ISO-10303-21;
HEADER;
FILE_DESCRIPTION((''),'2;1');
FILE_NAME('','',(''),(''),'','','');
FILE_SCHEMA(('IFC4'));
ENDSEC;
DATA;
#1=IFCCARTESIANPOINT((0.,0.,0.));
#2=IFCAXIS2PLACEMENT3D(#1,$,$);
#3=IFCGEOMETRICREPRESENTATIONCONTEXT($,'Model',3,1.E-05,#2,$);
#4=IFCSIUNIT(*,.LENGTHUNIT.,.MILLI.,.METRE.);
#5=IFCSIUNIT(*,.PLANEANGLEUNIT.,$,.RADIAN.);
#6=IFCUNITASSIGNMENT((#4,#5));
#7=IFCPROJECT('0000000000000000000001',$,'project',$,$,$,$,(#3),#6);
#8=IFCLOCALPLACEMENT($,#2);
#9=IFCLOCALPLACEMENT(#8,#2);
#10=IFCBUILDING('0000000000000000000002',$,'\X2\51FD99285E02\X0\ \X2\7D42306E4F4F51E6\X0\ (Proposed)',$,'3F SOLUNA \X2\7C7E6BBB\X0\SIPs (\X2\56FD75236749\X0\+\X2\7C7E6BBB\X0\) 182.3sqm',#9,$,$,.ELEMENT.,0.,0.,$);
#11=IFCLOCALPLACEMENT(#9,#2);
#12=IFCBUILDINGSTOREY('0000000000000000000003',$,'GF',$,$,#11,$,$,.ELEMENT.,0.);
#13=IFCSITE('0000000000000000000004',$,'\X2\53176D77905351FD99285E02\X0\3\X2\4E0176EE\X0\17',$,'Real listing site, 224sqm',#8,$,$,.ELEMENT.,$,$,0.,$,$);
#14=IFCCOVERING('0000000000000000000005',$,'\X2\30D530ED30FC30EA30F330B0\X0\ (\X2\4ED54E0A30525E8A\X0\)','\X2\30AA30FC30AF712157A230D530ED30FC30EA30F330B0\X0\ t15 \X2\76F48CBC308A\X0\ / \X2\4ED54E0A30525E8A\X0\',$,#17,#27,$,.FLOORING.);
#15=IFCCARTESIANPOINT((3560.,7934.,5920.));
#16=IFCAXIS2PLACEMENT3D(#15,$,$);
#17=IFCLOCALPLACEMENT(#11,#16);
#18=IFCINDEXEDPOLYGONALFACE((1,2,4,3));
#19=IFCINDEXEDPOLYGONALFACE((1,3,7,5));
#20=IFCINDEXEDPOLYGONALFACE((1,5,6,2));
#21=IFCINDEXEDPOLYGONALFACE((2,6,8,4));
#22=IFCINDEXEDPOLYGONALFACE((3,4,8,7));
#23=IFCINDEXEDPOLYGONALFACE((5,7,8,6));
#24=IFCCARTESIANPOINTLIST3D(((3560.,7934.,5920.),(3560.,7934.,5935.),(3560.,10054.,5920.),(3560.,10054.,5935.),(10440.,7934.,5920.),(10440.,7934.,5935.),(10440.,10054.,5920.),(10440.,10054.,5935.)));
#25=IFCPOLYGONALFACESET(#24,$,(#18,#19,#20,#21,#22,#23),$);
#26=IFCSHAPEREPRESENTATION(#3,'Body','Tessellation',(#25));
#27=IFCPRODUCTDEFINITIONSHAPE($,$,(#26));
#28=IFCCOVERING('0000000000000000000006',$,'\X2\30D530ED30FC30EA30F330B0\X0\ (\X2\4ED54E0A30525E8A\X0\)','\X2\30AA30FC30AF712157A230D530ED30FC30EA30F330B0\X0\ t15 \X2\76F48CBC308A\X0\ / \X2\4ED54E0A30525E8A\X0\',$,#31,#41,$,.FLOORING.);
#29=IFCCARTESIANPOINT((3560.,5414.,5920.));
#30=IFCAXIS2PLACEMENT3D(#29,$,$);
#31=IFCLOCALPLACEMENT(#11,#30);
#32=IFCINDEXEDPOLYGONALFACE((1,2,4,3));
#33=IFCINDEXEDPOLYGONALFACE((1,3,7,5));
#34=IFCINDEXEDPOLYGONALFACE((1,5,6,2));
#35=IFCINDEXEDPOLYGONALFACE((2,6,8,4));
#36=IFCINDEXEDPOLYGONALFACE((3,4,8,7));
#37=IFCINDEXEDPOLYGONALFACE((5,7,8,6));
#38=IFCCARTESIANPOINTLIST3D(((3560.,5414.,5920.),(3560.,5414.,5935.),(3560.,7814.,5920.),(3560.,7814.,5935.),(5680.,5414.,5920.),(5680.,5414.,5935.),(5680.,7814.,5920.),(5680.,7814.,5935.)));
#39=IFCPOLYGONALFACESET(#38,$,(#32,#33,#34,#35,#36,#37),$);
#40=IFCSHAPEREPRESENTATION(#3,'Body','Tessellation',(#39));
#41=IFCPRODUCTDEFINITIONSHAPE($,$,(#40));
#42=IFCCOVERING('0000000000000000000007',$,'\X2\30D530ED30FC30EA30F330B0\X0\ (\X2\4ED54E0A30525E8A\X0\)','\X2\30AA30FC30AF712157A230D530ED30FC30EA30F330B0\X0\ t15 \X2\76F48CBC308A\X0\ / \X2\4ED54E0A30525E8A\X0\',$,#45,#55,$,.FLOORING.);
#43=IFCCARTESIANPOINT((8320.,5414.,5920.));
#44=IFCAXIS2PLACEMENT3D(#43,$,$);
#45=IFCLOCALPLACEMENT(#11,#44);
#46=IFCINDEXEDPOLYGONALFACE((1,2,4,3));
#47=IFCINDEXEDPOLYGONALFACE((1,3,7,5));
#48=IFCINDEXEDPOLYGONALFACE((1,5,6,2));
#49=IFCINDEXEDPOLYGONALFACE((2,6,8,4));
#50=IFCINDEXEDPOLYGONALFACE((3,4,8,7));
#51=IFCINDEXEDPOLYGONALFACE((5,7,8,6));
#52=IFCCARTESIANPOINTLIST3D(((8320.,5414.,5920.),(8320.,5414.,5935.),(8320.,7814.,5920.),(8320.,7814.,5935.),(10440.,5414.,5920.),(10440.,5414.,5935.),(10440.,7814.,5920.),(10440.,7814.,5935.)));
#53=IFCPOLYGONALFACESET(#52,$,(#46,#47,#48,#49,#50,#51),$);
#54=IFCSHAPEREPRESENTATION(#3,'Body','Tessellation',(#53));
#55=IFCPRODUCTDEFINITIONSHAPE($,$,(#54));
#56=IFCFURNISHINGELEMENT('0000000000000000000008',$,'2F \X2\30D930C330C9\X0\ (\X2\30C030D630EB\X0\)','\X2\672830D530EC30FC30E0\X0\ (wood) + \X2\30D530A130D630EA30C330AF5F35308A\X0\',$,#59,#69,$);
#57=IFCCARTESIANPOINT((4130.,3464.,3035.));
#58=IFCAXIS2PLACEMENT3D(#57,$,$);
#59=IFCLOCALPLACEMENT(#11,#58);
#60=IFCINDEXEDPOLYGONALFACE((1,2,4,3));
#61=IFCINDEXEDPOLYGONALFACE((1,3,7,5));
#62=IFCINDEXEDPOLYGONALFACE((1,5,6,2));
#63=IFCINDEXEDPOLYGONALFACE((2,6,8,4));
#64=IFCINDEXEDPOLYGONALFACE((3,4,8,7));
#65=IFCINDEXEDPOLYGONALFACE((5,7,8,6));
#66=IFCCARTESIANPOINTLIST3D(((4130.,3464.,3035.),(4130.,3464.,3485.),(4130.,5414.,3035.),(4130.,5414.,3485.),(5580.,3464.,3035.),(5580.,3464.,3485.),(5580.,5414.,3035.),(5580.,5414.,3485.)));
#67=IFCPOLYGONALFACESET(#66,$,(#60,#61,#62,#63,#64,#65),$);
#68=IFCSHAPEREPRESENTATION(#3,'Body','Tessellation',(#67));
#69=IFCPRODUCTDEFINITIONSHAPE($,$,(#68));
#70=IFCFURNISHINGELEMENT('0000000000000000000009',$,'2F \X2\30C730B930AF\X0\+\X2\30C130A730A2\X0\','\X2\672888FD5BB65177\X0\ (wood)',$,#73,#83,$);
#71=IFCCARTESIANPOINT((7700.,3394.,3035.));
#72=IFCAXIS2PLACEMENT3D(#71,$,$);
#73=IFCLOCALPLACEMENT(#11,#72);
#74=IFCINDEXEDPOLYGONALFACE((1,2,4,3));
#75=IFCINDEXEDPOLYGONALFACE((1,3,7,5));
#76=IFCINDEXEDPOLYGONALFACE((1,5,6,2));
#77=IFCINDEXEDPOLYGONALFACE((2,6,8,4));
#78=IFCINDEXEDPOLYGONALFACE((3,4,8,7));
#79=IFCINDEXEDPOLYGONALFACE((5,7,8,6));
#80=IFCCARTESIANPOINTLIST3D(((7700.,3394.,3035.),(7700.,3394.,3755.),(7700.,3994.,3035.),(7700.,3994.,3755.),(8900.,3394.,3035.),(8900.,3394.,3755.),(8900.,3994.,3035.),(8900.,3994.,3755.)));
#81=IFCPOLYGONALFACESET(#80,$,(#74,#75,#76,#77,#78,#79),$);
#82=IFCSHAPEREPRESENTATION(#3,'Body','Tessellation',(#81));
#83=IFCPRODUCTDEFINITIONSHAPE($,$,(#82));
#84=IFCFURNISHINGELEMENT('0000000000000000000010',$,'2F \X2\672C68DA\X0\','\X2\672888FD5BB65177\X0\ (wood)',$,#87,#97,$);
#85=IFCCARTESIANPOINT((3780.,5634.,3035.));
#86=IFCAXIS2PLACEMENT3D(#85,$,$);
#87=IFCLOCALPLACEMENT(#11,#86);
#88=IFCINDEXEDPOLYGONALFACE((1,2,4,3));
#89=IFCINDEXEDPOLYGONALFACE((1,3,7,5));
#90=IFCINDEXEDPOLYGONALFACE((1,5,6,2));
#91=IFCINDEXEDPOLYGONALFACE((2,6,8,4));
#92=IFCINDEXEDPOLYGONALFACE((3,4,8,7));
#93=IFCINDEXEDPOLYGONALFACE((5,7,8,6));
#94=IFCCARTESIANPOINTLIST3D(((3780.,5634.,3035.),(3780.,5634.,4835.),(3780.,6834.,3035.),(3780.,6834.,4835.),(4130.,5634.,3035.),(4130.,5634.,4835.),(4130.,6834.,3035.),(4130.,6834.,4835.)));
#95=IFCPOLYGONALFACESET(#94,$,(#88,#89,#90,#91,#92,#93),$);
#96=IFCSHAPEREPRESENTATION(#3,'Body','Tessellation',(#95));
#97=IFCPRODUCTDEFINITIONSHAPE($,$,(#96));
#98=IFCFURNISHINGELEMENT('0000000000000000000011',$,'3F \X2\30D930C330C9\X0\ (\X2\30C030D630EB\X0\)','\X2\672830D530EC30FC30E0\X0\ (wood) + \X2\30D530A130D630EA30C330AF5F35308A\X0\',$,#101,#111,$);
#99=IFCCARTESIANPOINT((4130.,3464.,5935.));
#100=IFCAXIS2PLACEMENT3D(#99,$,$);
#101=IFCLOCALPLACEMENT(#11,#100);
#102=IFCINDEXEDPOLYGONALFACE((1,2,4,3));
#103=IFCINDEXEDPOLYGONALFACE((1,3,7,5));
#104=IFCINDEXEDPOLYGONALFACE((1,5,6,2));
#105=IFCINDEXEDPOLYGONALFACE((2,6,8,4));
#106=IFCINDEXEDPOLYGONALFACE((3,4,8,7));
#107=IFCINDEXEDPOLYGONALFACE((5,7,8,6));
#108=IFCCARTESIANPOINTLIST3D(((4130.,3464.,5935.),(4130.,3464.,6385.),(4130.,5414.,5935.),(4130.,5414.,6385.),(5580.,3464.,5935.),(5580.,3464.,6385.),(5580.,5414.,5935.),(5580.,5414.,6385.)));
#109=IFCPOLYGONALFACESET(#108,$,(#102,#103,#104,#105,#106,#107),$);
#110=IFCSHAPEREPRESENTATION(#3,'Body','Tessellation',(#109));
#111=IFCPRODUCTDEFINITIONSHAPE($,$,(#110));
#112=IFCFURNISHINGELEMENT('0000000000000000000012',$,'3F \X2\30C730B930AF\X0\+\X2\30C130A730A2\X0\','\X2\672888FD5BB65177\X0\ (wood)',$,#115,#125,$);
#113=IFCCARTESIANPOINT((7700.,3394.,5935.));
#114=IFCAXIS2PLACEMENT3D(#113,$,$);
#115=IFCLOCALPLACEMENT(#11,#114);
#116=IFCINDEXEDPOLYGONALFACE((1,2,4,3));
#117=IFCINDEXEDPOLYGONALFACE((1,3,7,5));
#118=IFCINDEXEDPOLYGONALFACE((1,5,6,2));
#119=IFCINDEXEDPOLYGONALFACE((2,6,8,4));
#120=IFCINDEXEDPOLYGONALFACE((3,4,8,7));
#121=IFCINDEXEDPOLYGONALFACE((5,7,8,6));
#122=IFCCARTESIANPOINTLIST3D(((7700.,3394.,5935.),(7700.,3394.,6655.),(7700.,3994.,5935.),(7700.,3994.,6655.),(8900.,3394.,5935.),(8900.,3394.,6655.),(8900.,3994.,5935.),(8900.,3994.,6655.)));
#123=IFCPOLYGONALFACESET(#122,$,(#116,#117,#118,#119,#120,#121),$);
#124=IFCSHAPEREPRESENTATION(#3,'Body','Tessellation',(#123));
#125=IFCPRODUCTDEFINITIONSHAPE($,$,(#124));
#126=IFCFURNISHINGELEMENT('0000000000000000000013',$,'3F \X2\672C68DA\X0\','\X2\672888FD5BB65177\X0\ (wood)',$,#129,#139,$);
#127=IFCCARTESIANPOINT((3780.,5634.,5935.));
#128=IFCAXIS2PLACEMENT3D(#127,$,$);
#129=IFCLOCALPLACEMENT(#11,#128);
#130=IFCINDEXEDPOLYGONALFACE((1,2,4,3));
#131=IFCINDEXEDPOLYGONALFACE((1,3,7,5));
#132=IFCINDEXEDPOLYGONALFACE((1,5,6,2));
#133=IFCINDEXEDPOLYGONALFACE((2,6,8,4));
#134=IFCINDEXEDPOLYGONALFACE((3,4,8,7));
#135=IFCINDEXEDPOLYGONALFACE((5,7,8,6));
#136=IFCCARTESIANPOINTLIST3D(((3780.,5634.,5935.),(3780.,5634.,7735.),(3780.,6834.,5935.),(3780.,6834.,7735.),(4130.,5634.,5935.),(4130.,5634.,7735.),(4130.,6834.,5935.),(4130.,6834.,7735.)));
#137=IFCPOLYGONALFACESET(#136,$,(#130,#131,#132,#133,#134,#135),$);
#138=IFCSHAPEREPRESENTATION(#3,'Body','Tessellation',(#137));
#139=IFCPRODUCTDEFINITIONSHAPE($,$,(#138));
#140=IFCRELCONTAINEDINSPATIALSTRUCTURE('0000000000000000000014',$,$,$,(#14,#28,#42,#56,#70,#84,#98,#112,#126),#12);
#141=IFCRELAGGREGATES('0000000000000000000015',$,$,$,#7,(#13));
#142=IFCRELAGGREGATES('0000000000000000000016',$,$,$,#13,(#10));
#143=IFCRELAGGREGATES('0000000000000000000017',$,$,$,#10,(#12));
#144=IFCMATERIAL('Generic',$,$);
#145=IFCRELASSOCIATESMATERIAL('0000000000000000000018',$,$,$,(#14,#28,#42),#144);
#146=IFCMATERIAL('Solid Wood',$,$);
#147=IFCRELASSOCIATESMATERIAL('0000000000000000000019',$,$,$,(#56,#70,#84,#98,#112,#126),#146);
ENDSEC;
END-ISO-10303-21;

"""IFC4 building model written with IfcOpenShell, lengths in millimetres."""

from ifc_helpers import new_model, si_unit, frame, frame_2d, origin, place, context, project, spatial, rectangle, extrude, material, element, save


model = new_model("IFC4")

# Units and contexts
model_context = context("Model", 3, precision=1e-05, world=origin())
ifc_project = project(units=[si_unit("LENGTHUNIT", "METRE", prefix="MILLI"), si_unit("PLANEANGLEUNIT", "RADIAN")], contexts=[model_context])

# Site, building, storey
site_placement = place(None, origin())
site = spatial("IfcSite", under=ifc_project, at=site_placement, Name="北海道函館市3丁目17", ObjectType="Real listing site, 224sqm", CompositionType="ELEMENT", RefElevation=0.0)
building_placement = place(site_placement, origin())
building = spatial("IfcBuilding", under=site, at=building_placement, Name="函館市 終の住処 (Proposed)", ObjectType="3F SOLUNA 籾殻SIPs (国産杉+籾殻) 182.3sqm", CompositionType="ELEMENT", ElevationOfRefHeight=0.0, ElevationOfTerrain=0.0)
storey_placement = place(building_placement, origin())
storey = spatial("IfcBuildingStorey", under=building, at=storey_placement, Name="GF", CompositionType="ELEMENT", Elevation=0.0)

# Shared definitions
ifc_material_1 = material(Name="Solid Wood")

# Shared definitions
ifc_material_2 = material(Name="Generic")

# Coverings
covering_1_placement = place(storey_placement, frame((3560.0, 7934.0, 5920.0)))
element("IfcCovering", 1, at=covering_1_placement, inside=storey, material=ifc_material_2, Name="フローリング (仕上げ床)", Description="オーク無垢フローリング t15 直貼り / 仕上げ床", PredefinedType="FLOORING", context=model_context, shape_type="SweptSolid", body=[
    extrude(rectangle(XDim=6880.0, YDim=2120.0, at=frame_2d((3440.0, 1060.0))), frame((3560.0, 7934.0, 5920.0)), (0.0, 0.0, 1.0), 15.0),
])
covering_2_placement = place(storey_placement, frame((3560.0, 5414.0, 5920.0)))
element("IfcCovering", 2, at=covering_2_placement, inside=storey, material=ifc_material_2, Name="フローリング (仕上げ床)", Description="オーク無垢フローリング t15 直貼り / 仕上げ床", PredefinedType="FLOORING", context=model_context, shape_type="SweptSolid", body=[
    extrude(rectangle(XDim=2120.0, YDim=2400.0, at=frame_2d((1060.0, 1200.0))), frame((3560.0, 5414.0, 5920.0)), (0.0, 0.0, 1.0), 15.0),
])
covering_3_placement = place(storey_placement, frame((8320.0, 5414.0, 5920.0)))
element("IfcCovering", 3, at=covering_3_placement, inside=storey, material=ifc_material_2, Name="フローリング (仕上げ床)", Description="オーク無垢フローリング t15 直貼り / 仕上げ床", PredefinedType="FLOORING", context=model_context, shape_type="SweptSolid", body=[
    extrude(rectangle(XDim=2120.0, YDim=2400.0, at=frame_2d((1060.0, 1200.0))), frame((8320.0, 5414.0, 5920.0)), (0.0, 0.0, 1.0), 15.0),
])

# Furnishing elements
furnishing_1_placement = place(storey_placement, frame((4130.0, 3464.0, 3035.0)))
element("IfcFurnishingElement", 4, at=furnishing_1_placement, inside=storey, material=ifc_material_1, Name="2F ベッド (ダブル)", Description="木フレーム (wood) + ファブリック張り", context=model_context, shape_type="SweptSolid", body=[
    extrude(rectangle(XDim=1450.0, YDim=1950.0, at=frame_2d((725.0, 975.0))), frame((4130.0, 3464.0, 3035.0)), (0.0, 0.0, 1.0), 450.0),
])
furnishing_2_placement = place(storey_placement, frame((7700.0, 3394.0, 3035.0)))
element("IfcFurnishingElement", 5, at=furnishing_2_placement, inside=storey, material=ifc_material_1, Name="2F デスク+チェア", Description="木製家具 (wood)", context=model_context, shape_type="SweptSolid", body=[
    extrude(rectangle(XDim=1200.0, YDim=600.0, at=frame_2d((600.0, 300.0))), frame((7700.0, 3394.0, 3035.0)), (0.0, 0.0, 1.0), 720.0),
])
furnishing_3_placement = place(storey_placement, frame((3780.0, 5634.0, 3035.0)))
element("IfcFurnishingElement", 6, at=furnishing_3_placement, inside=storey, material=ifc_material_1, Name="2F 本棚", Description="木製家具 (wood)", context=model_context, shape_type="SweptSolid", body=[
    extrude(rectangle(XDim=350.0, YDim=1200.0, at=frame_2d((175.0, 600.0))), frame((3780.0, 5634.0, 3035.0)), (0.0, 0.0, 1.0), 1800.0),
])
furnishing_4_placement = place(storey_placement, frame((4130.0, 3464.0, 5935.0)))
element("IfcFurnishingElement", 7, at=furnishing_4_placement, inside=storey, material=ifc_material_1, Name="3F ベッド (ダブル)", Description="木フレーム (wood) + ファブリック張り", context=model_context, shape_type="SweptSolid", body=[
    extrude(rectangle(XDim=1450.0, YDim=1950.0, at=frame_2d((725.0, 975.0))), frame((4130.0, 3464.0, 5935.0)), (0.0, 0.0, 1.0), 450.0),
])
furnishing_5_placement = place(storey_placement, frame((7700.0, 3394.0, 5935.0)))
element("IfcFurnishingElement", 8, at=furnishing_5_placement, inside=storey, material=ifc_material_1, Name="3F デスク+チェア", Description="木製家具 (wood)", context=model_context, shape_type="SweptSolid", body=[
    extrude(rectangle(XDim=1200.0, YDim=600.0, at=frame_2d((600.0, 300.0))), frame((7700.0, 3394.0, 5935.0)), (0.0, 0.0, 1.0), 720.0),
])
furnishing_6_placement = place(storey_placement, frame((3780.0, 5634.0, 5935.0)))
element("IfcFurnishingElement", 9, at=furnishing_6_placement, inside=storey, material=ifc_material_1, Name="3F 本棚", Description="木製家具 (wood)", context=model_context, shape_type="SweptSolid", body=[
    extrude(rectangle(XDim=350.0, YDim=1200.0, at=frame_2d((175.0, 600.0))), frame((3780.0, 5634.0, 5935.0)), (0.0, 0.0, 1.0), 1800.0),
])

save(model, "model.ifc")
